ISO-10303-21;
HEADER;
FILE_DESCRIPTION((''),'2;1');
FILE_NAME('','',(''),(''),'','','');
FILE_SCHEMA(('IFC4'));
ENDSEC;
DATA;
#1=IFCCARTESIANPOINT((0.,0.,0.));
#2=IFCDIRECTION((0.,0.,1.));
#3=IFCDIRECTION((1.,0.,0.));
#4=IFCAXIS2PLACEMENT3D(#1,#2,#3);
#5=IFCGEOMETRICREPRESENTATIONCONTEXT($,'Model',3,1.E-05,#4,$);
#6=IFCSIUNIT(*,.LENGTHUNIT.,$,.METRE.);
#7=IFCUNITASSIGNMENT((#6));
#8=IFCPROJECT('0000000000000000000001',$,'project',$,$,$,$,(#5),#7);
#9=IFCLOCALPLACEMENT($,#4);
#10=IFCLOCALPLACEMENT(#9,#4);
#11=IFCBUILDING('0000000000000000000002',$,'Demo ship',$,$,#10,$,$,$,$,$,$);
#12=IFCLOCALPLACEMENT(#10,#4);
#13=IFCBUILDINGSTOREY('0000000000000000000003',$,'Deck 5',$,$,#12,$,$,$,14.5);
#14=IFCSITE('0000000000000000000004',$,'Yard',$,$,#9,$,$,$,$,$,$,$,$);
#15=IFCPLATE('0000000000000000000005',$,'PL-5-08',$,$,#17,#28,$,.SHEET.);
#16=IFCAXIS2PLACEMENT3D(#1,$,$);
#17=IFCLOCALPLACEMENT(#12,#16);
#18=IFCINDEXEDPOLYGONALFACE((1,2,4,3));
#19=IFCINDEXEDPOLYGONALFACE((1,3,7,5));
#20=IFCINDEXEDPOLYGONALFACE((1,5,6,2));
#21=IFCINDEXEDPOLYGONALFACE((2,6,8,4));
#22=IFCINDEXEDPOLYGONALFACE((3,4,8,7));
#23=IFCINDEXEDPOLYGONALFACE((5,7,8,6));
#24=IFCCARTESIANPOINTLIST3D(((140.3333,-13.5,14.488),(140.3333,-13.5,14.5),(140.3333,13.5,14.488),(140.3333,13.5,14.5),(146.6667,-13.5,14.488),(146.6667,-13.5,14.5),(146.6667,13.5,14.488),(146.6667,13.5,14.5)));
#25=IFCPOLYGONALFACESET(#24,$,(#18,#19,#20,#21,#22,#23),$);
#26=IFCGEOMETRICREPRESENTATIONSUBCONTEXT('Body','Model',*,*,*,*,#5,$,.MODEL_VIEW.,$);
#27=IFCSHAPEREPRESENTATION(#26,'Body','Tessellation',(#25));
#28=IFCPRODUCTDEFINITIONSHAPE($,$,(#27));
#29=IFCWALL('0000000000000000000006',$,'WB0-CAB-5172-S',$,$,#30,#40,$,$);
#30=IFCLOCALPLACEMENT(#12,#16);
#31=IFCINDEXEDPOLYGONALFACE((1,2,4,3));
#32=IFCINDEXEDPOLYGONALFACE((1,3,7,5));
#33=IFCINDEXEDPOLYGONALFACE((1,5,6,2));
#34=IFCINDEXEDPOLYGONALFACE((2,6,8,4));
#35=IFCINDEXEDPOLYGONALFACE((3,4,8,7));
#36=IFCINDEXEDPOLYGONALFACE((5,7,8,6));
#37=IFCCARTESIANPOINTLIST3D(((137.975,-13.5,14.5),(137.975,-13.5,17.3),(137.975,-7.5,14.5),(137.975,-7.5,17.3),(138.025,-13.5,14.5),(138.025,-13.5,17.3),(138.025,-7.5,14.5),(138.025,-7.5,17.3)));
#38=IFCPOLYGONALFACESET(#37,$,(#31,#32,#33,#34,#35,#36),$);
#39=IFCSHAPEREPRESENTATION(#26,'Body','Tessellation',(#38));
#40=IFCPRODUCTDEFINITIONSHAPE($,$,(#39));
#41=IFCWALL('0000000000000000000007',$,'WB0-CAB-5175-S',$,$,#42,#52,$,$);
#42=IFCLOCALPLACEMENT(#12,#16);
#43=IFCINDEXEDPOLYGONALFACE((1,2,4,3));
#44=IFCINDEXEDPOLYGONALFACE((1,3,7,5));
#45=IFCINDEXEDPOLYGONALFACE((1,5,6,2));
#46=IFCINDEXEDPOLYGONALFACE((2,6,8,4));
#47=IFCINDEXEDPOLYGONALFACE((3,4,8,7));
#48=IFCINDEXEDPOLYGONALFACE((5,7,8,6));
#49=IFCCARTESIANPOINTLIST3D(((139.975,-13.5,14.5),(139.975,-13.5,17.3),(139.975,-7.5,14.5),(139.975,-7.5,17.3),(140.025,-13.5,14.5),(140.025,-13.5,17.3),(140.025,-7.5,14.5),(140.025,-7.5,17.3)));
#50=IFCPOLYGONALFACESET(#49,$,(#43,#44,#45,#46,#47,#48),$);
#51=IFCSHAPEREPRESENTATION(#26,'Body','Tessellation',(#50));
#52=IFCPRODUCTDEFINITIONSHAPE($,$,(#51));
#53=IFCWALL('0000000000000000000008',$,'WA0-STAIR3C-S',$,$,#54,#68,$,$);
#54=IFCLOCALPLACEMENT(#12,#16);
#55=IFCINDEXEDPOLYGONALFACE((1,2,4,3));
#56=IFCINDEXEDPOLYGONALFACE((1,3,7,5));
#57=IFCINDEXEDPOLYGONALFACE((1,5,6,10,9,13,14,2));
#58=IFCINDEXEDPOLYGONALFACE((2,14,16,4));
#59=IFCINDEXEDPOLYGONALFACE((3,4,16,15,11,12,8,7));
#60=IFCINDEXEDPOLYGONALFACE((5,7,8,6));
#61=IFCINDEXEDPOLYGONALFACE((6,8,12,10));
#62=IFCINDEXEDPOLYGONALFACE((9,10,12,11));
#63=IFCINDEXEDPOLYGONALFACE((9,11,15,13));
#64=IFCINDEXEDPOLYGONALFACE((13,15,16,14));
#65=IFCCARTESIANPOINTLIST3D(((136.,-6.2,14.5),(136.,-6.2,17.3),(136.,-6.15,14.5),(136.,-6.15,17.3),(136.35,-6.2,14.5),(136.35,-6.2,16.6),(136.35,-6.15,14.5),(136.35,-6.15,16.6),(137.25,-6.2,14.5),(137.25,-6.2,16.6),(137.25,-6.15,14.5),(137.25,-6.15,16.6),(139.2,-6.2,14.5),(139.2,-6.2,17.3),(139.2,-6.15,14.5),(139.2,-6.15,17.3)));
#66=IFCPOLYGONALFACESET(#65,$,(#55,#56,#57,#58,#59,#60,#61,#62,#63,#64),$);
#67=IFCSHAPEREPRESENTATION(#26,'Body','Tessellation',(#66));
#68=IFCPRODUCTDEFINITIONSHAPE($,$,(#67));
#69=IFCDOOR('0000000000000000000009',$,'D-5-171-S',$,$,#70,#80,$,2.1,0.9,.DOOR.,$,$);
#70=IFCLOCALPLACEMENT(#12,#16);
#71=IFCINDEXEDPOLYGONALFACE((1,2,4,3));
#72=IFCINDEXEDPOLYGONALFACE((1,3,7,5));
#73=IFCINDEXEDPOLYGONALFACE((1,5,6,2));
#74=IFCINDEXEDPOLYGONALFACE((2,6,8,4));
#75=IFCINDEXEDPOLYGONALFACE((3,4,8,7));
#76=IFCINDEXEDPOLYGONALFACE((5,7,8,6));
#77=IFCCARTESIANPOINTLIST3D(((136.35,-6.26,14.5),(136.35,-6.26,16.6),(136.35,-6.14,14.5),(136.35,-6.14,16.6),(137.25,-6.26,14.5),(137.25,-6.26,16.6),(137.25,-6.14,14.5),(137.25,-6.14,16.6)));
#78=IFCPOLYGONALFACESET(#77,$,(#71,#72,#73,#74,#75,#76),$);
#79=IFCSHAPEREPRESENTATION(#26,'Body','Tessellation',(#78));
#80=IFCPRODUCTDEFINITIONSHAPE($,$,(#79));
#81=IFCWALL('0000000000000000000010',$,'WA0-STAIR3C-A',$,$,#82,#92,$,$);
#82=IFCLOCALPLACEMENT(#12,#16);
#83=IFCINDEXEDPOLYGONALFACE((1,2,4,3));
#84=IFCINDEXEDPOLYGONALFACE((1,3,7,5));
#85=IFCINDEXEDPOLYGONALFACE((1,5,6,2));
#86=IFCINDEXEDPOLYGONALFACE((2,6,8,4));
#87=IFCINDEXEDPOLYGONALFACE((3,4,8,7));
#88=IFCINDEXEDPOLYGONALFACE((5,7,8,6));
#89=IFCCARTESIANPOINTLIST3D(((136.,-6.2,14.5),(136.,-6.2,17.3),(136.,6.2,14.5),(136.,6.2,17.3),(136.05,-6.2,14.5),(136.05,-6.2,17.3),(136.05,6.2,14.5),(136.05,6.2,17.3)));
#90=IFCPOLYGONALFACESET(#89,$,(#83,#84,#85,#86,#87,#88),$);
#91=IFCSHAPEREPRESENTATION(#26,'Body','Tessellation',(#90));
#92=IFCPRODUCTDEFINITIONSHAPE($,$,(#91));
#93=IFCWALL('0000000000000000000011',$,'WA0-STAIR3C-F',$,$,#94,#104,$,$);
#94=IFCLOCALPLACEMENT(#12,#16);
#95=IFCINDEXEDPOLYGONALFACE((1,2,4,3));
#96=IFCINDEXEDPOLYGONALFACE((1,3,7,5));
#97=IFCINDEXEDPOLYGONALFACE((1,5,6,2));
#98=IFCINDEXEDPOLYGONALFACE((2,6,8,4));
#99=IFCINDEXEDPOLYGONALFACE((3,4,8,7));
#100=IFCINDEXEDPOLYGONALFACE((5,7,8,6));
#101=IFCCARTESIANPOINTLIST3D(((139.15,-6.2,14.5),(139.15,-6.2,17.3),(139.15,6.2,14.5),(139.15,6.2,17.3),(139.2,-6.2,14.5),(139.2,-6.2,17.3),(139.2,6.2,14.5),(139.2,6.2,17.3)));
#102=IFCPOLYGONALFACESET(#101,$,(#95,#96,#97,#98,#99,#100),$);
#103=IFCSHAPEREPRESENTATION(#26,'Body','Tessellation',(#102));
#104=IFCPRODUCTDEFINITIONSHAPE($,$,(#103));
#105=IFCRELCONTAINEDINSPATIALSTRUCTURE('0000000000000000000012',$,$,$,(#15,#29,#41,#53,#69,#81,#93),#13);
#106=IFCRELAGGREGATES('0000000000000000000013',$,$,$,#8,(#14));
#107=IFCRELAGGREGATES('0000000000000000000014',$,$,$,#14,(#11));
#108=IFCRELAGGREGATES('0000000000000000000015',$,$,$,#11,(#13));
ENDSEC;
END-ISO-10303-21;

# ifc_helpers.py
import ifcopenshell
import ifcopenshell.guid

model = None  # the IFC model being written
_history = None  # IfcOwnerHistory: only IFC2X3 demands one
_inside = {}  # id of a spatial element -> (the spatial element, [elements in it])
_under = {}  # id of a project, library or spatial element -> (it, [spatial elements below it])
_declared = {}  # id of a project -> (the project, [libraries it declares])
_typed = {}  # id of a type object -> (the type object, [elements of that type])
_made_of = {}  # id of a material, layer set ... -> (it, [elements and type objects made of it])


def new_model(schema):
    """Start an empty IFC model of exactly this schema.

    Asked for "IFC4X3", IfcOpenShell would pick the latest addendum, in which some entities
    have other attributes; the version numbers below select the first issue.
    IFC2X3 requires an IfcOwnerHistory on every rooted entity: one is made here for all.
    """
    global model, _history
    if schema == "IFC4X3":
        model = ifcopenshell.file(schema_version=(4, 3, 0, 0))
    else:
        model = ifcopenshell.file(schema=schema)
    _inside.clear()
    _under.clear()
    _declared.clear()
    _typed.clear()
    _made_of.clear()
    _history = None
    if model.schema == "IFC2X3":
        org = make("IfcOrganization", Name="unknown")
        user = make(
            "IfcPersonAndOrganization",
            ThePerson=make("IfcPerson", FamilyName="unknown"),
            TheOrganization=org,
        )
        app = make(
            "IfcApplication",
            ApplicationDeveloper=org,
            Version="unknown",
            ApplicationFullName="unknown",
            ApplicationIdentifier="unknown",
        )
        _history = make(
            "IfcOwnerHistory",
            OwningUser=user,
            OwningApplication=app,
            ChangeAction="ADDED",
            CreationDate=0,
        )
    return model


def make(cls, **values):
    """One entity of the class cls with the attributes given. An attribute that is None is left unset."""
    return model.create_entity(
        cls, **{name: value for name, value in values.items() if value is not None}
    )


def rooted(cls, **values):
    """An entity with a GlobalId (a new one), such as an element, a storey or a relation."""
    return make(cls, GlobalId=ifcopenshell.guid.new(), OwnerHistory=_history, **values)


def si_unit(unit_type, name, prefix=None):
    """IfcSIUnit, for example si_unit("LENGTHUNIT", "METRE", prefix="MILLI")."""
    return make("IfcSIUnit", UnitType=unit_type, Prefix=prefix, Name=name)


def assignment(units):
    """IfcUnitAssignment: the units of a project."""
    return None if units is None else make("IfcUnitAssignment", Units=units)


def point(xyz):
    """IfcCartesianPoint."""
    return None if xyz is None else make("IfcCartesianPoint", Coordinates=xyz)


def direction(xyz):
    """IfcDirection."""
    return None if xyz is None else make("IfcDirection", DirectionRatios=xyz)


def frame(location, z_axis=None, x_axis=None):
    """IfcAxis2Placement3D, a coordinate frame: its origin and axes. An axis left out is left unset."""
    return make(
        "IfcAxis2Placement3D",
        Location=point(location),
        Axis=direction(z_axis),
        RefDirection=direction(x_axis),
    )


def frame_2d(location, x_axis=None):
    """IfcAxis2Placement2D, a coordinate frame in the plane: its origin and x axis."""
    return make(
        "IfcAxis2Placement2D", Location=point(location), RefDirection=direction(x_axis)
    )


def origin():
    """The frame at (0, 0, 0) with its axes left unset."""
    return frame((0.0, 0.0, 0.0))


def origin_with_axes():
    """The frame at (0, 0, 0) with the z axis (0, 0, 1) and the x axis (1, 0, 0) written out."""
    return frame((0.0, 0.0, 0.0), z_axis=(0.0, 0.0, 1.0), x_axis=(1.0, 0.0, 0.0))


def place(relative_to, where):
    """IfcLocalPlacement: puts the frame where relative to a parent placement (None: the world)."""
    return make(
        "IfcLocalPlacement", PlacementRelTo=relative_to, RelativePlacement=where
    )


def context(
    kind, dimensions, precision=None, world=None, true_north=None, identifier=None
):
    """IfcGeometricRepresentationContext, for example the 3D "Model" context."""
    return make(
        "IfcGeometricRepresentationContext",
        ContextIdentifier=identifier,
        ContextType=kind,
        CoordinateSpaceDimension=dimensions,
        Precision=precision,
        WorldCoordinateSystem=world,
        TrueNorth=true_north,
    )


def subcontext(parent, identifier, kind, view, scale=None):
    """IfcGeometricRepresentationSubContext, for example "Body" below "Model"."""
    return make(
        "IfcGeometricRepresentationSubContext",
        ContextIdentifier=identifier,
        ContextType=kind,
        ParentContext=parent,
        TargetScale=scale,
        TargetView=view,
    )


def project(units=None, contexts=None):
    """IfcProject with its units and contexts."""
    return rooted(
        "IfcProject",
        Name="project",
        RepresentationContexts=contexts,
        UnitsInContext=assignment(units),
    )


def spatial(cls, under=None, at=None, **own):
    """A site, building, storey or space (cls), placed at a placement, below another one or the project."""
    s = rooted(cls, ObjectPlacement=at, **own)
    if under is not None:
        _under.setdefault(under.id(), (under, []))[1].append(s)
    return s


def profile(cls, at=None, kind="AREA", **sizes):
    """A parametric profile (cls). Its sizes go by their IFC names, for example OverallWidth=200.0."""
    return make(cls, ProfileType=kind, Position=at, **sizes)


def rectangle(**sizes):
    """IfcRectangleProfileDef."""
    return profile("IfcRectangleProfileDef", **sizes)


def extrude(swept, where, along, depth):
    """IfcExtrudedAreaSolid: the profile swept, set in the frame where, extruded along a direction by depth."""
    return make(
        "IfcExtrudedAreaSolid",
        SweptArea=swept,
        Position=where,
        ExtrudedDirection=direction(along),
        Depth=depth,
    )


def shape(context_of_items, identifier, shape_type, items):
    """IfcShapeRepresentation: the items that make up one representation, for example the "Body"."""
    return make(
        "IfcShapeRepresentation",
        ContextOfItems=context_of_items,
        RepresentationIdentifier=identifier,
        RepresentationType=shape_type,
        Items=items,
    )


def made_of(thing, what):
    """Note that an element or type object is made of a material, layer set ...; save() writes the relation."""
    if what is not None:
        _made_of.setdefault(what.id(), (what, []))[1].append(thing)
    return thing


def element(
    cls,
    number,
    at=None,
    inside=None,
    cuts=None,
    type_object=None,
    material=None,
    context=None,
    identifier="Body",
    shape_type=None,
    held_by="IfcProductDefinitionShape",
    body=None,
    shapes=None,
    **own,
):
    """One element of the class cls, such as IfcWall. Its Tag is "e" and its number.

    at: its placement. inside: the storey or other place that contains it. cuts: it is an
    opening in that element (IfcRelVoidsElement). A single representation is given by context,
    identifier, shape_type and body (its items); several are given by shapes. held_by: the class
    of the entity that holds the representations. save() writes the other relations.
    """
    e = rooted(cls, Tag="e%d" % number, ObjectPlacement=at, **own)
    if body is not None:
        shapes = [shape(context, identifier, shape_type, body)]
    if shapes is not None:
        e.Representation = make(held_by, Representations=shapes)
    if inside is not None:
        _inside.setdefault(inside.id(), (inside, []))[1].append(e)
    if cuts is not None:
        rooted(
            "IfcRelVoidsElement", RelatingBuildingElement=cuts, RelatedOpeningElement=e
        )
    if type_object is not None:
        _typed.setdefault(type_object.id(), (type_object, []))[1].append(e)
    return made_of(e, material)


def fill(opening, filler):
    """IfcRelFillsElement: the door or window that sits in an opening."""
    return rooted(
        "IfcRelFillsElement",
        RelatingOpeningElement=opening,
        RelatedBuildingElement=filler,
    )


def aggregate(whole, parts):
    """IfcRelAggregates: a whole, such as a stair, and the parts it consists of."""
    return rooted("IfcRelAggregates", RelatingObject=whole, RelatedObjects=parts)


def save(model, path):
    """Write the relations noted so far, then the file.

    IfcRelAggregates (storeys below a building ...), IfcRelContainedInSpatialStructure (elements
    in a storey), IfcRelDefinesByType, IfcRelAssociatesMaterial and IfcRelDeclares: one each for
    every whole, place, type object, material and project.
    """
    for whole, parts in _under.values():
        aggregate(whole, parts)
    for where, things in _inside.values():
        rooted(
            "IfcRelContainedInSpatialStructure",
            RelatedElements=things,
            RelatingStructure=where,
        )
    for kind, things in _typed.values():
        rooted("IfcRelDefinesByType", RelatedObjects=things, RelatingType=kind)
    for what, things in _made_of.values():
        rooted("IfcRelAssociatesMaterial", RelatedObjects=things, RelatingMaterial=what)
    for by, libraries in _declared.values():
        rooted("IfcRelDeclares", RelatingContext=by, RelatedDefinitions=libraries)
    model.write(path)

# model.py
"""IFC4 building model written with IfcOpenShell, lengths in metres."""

from ifc_helpers import new_model, si_unit, frame, frame_2d, origin, origin_with_axes, place, context, subcontext, project, spatial, rectangle, extrude, element, fill, save


model = new_model("IFC4")

# Units and contexts
model_context = context("Model", 3, precision=1e-05, world=origin_with_axes())
body_context = subcontext(model_context, "Body", "Model", "MODEL_VIEW")
ifc_project = project(units=[si_unit("LENGTHUNIT", "METRE")], contexts=[model_context])

# Site, building, storey
site_placement = place(None, origin_with_axes())
site = spatial("IfcSite", under=ifc_project, at=site_placement, Name="Yard")
building_placement = place(site_placement, origin_with_axes())
building = spatial("IfcBuilding", under=site, at=building_placement, Name="Demo ship")
storey_placement = place(building_placement, origin_with_axes())
storey = spatial("IfcBuildingStorey", under=building, at=storey_placement, Name="Deck 5", Elevation=14.5)

# Plate
plate_placement = place(storey_placement, frame((140.3333, -13.5, 14.488), z_axis=(0.0, 0.0, 1.0), x_axis=(1.0, 0.0, 0.0)))
element("IfcPlate", 1, at=plate_placement, inside=storey, Name="PL-5-08", PredefinedType="SHEET", context=body_context, shape_type="SweptSolid", body=[
    extrude(rectangle(XDim=6.3334, YDim=27.0, at=frame_2d((3.1667, 13.5))), origin(), (0.0, 0.0, 1.0), 0.012),
])

# Walls
for number, where, z_axis, x_axis, name in (
    (2, (137.975, -13.5, 14.5), (0.0, 0.0, 1.0), (1.0, 0.0, 0.0), "WB0-CAB-5172-S"),
    (3, (139.975, -13.5, 14.5), (0.0, 0.0, 1.0), (1.0, 0.0, 0.0), "WB0-CAB-5175-S"),
):
    element("IfcWall", number, at=place(storey_placement, frame(where, z_axis=z_axis, x_axis=x_axis)), inside=storey, Name=name, context=body_context, shape_type="SweptSolid", body=[
        extrude(rectangle(XDim=0.05, YDim=6.0, at=frame_2d((0.025, 3.0))), origin(), (0.0, 0.0, 1.0), 2.8),
    ])

# Wall, opening, door
wall_placement = place(storey_placement, frame((136.0, -6.2, 14.5), z_axis=(0.0, 0.0, 1.0), x_axis=(1.0, 0.0, 0.0)))
wall = element("IfcWall", 4, at=wall_placement, inside=storey, Name="WA0-STAIR3C-S", context=body_context, shape_type="SweptSolid", body=[
    extrude(rectangle(XDim=3.2, YDim=0.05, at=frame_2d((1.6, 0.025))), origin(), (0.0, 0.0, 1.0), 2.8),
])
opening_placement = place(None, frame((136.35, -6.26, 14.5), z_axis=(0.0, 0.0, 1.0), x_axis=(1.0, 0.0, 0.0)))
opening = element("IfcOpeningElement", 5, at=opening_placement, cuts=wall, context=body_context, shape_type="SweptSolid", body=[
    extrude(rectangle(XDim=0.9, YDim=0.12, at=frame_2d((0.45, 0.06))), origin(), (0.0, 0.0, 1.0), 2.1),
])
door_placement = place(storey_placement, frame((136.35, -6.26, 14.5), z_axis=(0.0, 0.0, 1.0), x_axis=(1.0, 0.0, 0.0)))
door = element("IfcDoor", 6, at=door_placement, inside=storey, Name="D-5-171-S", OverallHeight=2.1, OverallWidth=0.9, PredefinedType="DOOR", context=body_context, shape_type="SweptSolid", body=[
    extrude(rectangle(XDim=0.9, YDim=0.12, at=frame_2d((0.45, 0.06))), origin(), (0.0, 0.0, 1.0), 2.1),
])
fill(opening, door)

# Walls
for number, where, z_axis, x_axis, name in (
    (7, (136.0, -6.2, 14.5), (0.0, 0.0, 1.0), (1.0, 0.0, 0.0), "WA0-STAIR3C-A"),
    (8, (139.15, -6.2, 14.5), (0.0, 0.0, 1.0), (1.0, 0.0, 0.0), "WA0-STAIR3C-F"),
):
    element("IfcWall", number, at=place(storey_placement, frame(where, z_axis=z_axis, x_axis=x_axis)), inside=storey, Name=name, context=body_context, shape_type="SweptSolid", body=[
        extrude(rectangle(XDim=0.05, YDim=12.4, at=frame_2d((0.025, 6.2))), origin(), (0.0, 0.0, 1.0), 2.8),
    ])

save(model, "model.ifc")
